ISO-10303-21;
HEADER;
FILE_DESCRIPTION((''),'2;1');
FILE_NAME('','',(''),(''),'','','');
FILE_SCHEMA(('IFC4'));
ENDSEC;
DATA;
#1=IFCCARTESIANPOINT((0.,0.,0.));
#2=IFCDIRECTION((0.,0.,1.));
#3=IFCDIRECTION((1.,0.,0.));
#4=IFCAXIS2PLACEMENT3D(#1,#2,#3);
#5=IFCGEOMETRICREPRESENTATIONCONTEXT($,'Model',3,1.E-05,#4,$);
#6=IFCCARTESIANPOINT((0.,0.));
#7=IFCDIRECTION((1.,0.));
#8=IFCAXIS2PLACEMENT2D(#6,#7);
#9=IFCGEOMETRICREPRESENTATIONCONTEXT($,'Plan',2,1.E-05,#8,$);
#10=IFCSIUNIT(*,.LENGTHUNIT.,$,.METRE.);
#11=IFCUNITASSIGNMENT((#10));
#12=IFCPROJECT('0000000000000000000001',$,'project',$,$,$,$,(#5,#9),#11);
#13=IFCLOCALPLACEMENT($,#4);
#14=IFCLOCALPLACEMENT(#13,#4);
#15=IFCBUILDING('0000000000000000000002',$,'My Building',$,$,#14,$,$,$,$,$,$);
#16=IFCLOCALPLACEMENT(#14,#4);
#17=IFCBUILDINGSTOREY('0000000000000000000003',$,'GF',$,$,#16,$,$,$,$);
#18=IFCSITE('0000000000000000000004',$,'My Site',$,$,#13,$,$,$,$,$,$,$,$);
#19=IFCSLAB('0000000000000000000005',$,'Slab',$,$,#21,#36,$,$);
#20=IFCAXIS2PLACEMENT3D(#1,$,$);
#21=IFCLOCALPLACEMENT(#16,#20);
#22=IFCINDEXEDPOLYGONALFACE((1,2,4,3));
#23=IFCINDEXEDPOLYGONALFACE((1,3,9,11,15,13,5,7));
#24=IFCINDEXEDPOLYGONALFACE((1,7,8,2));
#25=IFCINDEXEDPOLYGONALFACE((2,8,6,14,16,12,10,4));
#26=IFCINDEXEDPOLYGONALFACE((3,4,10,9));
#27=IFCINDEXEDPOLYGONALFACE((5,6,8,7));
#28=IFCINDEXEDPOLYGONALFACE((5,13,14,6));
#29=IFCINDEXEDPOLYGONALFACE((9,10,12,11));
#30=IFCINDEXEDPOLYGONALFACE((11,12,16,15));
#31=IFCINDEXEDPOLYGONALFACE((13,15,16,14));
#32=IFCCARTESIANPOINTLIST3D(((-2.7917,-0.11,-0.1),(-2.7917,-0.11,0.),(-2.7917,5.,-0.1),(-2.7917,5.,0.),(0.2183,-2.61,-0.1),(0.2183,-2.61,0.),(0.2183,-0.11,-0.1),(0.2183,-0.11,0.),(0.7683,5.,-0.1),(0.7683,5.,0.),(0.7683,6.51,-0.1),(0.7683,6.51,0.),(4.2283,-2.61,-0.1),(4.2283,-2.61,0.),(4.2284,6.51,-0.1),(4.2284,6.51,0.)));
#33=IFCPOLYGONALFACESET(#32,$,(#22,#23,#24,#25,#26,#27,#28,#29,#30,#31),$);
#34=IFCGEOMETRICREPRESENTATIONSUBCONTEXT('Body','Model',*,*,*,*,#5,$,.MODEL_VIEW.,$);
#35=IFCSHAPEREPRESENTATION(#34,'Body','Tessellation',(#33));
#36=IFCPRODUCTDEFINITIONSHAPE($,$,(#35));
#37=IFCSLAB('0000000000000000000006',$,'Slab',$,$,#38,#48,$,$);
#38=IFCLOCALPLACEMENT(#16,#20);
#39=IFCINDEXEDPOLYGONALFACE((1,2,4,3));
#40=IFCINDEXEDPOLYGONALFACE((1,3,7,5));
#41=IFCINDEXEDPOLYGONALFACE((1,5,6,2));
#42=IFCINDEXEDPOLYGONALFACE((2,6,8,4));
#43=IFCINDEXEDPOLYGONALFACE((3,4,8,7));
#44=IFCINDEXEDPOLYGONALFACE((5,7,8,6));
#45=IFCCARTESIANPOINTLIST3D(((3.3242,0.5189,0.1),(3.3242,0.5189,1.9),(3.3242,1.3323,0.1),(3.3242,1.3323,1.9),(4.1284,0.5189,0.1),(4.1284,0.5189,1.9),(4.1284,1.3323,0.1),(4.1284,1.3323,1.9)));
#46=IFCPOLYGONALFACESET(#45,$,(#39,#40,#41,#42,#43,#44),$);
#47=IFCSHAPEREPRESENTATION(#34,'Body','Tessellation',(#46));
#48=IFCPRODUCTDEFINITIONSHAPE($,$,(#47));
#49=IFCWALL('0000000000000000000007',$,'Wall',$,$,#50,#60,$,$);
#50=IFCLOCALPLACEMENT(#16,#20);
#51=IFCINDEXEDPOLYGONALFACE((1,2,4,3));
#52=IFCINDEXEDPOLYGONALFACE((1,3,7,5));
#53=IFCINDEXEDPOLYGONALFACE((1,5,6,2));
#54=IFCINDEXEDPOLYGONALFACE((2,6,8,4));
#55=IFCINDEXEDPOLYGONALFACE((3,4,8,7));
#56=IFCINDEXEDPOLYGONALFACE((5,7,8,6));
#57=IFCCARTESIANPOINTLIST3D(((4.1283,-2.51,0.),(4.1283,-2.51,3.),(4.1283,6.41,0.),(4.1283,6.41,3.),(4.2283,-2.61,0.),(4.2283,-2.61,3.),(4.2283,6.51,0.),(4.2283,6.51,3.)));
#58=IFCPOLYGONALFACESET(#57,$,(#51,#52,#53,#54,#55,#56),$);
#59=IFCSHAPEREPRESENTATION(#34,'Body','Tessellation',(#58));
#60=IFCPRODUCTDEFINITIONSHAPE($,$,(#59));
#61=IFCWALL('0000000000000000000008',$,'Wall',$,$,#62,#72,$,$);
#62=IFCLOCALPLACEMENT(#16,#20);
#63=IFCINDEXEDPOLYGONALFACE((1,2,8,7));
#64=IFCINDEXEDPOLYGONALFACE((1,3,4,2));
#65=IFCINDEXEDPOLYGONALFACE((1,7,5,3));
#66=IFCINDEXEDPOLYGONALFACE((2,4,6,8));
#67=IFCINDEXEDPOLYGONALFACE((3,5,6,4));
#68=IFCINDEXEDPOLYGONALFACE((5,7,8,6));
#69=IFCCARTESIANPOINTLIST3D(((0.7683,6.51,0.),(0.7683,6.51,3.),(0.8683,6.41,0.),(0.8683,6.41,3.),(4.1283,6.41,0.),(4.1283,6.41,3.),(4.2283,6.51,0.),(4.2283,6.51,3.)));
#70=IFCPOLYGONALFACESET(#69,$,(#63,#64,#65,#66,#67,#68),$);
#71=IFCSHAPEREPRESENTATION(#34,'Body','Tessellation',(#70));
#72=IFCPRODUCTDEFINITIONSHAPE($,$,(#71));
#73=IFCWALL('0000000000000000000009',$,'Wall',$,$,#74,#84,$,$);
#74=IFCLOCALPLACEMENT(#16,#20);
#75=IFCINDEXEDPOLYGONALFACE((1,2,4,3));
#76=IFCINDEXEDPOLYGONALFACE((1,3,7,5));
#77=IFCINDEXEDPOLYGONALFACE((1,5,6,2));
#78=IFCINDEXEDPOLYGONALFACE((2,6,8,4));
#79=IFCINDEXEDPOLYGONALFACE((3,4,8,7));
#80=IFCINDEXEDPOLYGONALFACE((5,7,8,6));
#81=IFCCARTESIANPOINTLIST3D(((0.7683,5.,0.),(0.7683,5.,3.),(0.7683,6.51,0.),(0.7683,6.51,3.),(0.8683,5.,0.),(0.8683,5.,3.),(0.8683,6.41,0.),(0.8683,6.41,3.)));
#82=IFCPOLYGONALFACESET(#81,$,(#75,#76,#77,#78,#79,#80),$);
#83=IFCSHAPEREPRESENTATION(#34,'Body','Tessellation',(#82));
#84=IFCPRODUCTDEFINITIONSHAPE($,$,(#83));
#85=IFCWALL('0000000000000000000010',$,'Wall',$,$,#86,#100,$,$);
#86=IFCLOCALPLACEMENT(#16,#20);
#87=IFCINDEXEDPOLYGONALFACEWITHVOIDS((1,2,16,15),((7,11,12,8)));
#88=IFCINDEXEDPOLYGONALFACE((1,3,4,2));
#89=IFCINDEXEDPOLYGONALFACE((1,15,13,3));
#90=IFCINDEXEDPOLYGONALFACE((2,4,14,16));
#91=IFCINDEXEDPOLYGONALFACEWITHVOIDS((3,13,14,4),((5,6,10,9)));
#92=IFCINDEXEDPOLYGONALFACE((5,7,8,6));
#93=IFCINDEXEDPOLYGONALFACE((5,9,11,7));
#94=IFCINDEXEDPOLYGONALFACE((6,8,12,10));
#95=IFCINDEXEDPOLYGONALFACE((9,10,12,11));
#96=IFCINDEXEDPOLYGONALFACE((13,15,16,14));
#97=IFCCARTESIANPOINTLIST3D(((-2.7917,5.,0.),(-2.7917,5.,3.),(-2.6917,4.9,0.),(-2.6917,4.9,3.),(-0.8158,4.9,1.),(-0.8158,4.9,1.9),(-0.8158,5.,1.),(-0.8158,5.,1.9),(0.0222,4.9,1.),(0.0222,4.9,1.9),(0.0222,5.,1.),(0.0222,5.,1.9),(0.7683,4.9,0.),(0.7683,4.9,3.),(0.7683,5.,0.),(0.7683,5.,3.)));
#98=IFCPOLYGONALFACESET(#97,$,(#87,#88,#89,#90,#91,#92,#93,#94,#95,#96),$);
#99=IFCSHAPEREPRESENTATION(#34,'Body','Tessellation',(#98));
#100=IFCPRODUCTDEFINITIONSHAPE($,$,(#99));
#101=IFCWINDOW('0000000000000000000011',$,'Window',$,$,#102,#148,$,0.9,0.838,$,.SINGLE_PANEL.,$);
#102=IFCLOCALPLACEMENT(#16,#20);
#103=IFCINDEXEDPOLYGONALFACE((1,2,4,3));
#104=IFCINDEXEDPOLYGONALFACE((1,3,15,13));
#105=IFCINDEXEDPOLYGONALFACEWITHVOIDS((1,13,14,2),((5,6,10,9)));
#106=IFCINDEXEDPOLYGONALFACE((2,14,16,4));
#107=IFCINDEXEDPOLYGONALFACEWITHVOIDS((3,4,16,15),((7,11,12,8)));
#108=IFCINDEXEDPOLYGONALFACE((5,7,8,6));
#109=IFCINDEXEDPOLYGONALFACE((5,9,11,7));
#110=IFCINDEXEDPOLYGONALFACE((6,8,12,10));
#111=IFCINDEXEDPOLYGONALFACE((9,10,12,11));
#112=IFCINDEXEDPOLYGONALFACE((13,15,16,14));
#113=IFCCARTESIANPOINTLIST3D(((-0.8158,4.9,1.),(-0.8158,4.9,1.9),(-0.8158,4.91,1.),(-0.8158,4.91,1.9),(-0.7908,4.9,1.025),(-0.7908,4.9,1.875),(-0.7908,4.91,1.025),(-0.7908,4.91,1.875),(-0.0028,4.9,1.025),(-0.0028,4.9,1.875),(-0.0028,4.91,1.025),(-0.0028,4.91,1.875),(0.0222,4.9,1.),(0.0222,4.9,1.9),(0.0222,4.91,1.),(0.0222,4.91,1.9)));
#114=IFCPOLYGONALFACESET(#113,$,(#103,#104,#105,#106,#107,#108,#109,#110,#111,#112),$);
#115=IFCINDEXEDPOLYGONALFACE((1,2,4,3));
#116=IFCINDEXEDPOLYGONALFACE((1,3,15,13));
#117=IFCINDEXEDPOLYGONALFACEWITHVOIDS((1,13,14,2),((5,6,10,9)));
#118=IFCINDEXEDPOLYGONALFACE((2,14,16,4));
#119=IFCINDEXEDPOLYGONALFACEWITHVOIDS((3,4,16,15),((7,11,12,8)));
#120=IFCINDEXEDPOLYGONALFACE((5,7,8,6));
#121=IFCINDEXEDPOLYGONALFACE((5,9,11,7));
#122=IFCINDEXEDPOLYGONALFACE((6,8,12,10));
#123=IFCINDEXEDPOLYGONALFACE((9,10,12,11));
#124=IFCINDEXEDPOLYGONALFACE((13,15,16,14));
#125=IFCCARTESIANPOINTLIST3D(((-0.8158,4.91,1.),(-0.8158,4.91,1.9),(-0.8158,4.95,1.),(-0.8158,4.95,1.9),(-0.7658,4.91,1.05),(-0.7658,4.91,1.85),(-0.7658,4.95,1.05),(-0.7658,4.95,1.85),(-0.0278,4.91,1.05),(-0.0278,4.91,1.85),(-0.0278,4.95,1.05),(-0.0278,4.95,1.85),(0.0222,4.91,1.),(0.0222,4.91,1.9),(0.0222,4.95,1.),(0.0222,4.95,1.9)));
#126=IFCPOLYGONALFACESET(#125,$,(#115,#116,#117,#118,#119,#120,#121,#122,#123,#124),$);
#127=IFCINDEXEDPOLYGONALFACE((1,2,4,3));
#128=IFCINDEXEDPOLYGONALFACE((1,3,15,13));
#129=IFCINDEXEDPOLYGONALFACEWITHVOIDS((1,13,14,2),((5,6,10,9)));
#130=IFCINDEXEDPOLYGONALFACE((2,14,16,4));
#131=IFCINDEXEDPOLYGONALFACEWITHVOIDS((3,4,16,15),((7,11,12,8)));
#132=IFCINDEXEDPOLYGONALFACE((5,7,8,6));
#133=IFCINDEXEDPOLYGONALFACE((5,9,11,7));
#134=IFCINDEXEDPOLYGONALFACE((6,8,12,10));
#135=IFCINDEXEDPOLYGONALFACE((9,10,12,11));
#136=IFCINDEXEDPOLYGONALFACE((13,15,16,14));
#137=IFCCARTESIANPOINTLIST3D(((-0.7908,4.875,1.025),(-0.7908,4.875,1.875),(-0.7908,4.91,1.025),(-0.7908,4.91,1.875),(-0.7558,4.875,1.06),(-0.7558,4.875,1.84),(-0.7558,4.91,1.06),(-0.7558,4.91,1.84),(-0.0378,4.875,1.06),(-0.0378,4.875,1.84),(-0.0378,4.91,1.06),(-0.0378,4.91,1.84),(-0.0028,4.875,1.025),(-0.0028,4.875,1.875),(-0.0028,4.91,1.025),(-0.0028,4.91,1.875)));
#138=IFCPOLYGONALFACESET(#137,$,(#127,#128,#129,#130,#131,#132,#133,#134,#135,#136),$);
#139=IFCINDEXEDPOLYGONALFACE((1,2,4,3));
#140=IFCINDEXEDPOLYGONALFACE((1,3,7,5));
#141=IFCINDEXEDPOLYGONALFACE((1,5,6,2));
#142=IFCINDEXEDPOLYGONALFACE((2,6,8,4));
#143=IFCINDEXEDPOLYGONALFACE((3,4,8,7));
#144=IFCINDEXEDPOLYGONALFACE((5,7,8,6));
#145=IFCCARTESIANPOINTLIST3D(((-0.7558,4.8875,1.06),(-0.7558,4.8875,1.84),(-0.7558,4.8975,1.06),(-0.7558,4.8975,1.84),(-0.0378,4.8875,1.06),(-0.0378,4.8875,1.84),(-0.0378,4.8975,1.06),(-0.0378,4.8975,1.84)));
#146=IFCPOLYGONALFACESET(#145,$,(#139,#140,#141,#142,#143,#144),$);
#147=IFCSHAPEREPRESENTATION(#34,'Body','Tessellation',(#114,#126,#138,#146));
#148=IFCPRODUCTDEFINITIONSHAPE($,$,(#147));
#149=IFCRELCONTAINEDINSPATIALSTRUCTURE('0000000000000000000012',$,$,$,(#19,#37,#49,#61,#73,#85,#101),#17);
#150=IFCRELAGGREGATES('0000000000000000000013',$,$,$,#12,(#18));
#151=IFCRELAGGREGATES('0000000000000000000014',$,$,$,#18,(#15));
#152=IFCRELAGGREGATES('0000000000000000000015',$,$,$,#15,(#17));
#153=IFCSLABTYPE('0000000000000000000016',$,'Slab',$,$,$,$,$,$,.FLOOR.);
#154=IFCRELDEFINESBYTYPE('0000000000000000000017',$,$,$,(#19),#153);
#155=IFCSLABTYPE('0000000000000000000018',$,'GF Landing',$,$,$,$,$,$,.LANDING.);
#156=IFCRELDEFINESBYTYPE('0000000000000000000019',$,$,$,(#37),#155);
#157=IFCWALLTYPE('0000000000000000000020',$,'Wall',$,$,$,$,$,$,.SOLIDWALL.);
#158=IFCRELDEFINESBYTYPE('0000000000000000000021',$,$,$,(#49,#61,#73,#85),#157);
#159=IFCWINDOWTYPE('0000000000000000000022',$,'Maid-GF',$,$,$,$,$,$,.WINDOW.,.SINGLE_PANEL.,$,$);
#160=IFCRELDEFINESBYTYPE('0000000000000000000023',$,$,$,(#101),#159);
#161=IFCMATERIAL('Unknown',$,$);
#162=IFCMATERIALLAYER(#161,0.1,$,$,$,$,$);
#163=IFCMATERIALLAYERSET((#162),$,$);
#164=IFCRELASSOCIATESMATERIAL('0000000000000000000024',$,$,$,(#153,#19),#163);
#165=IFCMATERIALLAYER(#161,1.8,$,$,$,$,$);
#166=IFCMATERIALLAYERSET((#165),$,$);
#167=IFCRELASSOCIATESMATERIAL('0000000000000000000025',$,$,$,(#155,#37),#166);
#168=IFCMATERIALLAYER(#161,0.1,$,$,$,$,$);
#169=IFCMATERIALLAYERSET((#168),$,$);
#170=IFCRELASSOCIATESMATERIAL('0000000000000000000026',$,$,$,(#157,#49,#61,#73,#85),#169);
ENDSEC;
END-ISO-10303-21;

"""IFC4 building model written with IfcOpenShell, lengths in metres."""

from ifc_helpers import new_model, entity, si_unit, frame, origin_with_axes, origin_2d_with_axis, place, context, subcontext, project, spatial, line, indexed_curve, outline, extrude, shape, source, transform, mapped, material, layer, layer_set, layer_usage, type_object, type_shapes, element, fill, save


model = new_model("IFC4")

# Units and contexts
model_context = context("Model", 3, precision=1e-05, world=origin_with_axes())
plan_context = context("Plan", 2, precision=1e-05, world=origin_2d_with_axis())
body_context_1 = subcontext(model_context, "Body", "Model", "MODEL_VIEW")
body_context_2 = subcontext(plan_context, "Body", "Plan", "PLAN_VIEW")
ifc_project = project(units=[si_unit("LENGTHUNIT", "METRE")], contexts=[model_context, plan_context])

# Site, building, storey
site_placement = place(None, origin_with_axes())
site = spatial("IfcSite", under=ifc_project, at=site_placement, Name="My Site")
building_placement = place(site_placement, origin_with_axes())
building = spatial("IfcBuilding", under=site, at=building_placement, Name="My Building")
storey_placement = place(building_placement, origin_with_axes())
storey = spatial("IfcBuildingStorey", under=building, at=storey_placement, Name="GF")

# Slabs
ifc_material = material(Name="Unknown")
ifc_layer_1 = layer(ifc_material, 0.1)
ifc_layer_set_1 = layer_set([ifc_layer_1])
ifc_layer_usage_1 = layer_usage(ifc_layer_set_1, "AXIS3", "POSITIVE", -0.1)
slab_type_1 = type_object("IfcSlabType", Name="Slab", PredefinedType="FLOOR", material=ifc_layer_set_1)
slab_1_placement = place(storey_placement, frame((0.2183, -2.61, 0.0), z_axis=(0.0, 0.0, 1.0), x_axis=(1.0, 0.0, 0.0)))
element("IfcSlab", 1, at=slab_1_placement, inside=storey, type_object=slab_type_1, material=ifc_layer_usage_1, Name="Slab", context=body_context_1, shape_type="SweptSolid", body=[
    extrude(outline(indexed_curve([(4.01, 0.0), (4.01, 9.12), (0.55, 9.12), (0.55, 7.61), (-3.01, 7.61), (-3.01, 2.5), (0.0, 2.5), (0.0, 0.0), (4.01, 0.0)])), frame((0.0, 0.0, -0.1), z_axis=(0.0, 0.0, 1.0), x_axis=(1.0, 0.0, 0.0)), (0.0, 0.0, 1.0), 0.1),
])
ifc_layer_2 = layer(ifc_material, 1.8)
ifc_layer_set_2 = layer_set([ifc_layer_2])
ifc_layer_usage_2 = layer_usage(ifc_layer_set_2, "AXIS3", "POSITIVE", -0.1)
slab_type_2 = type_object("IfcSlabType", Name="GF Landing", PredefinedType="LANDING", material=ifc_layer_set_2)
slab_2_placement = place(storey_placement, frame((3.3242, 1.3323, 0.2), z_axis=(0.0, 0.0, 1.0), x_axis=(1.0, 0.0, 0.0)))
element("IfcSlab", 2, at=slab_2_placement, inside=storey, type_object=slab_type_2, material=ifc_layer_usage_2, Name="Slab", context=body_context_1, shape_type="SweptSolid", body=[
    extrude(outline(indexed_curve([(0.0, 0.0), (0.0, -0.8134), (0.8042, -0.8134), (0.8042, 0.0), (0.0, 0.0)])), frame((0.0, 0.0, -0.1), z_axis=(0.0, 0.0, 1.0), x_axis=(1.0, 0.0, 0.0)), (0.0, 0.0, 1.0), 1.8),
])

# Shared definitions
ifc_layer_3 = layer(ifc_material, 0.1)
ifc_layer_set_3 = layer_set([ifc_layer_3])
wall_type = type_object("IfcWallType", Name="Wall", PredefinedType="SOLIDWALL", material=ifc_layer_set_3)

# Walls
ifc_layer_usage_3 = layer_usage(ifc_layer_set_3, "AXIS2", "POSITIVE", 0.0)
wall_1_placement = place(storey_placement, frame((4.2283, -2.61, 0.0), z_axis=(0.0, 0.0, 1.0), x_axis=(0.0, 1.0, 0.0)))
element("IfcWall", 3, at=wall_1_placement, inside=storey, type_object=wall_type, material=ifc_layer_usage_3, Name="Wall", context=body_context_1, shape_type="SweptSolid", body=[
    extrude(outline(indexed_curve([(0.0, 0.0), (0.1, 0.1), (9.02, 0.1), (9.12, 0.0)], segments=[line(1, 2, 3, 4, 1)])), origin_with_axes(), (0.0, 0.0, 1.0), 3.0),
])
ifc_layer_usage_4 = layer_usage(ifc_layer_set_3, "AXIS2", "POSITIVE", 0.0)
wall_2_placement = place(storey_placement, frame((4.2283, 6.51, 0.0), z_axis=(0.0, 0.0, 1.0), x_axis=(-1.0, 0.0, 0.0)))
element("IfcWall", 4, at=wall_2_placement, inside=storey, type_object=wall_type, material=ifc_layer_usage_4, Name="Wall", context=body_context_1, shape_type="SweptSolid", body=[
    extrude(outline(indexed_curve([(0.0, 0.0), (0.1, 0.1), (3.36, 0.1), (3.46, 0.0)], segments=[line(1, 2, 3, 4, 1)])), origin_with_axes(), (0.0, 0.0, 1.0), 3.0),
])
ifc_layer_usage_5 = layer_usage(ifc_layer_set_3, "AXIS2", "POSITIVE", 0.0)
wall_3_placement = place(storey_placement, frame((0.7683, 6.51, 0.0), z_axis=(0.0, 0.0, 1.0), x_axis=(0.0, -1.0, 0.0)))
element("IfcWall", 5, at=wall_3_placement, inside=storey, type_object=wall_type, material=ifc_layer_usage_5, Name="Wall", context=body_context_1, shape_type="SweptSolid", body=[
    extrude(outline(indexed_curve([(0.0, 0.0), (0.1, 0.1), (1.51, 0.1), (1.51, 0.0)], segments=[line(1, 2, 3, 4, 1)])), origin_with_axes(), (0.0, 0.0, 1.0), 3.0),
])

# Wall, opening, window
ifc_layer_usage_6 = layer_usage(ifc_layer_set_3, "AXIS2", "POSITIVE", 0.0)
wall_4_placement = place(storey_placement, frame((0.7683, 5.0, 0.0), z_axis=(0.0, 0.0, 1.0), x_axis=(-1.0, 0.0, 0.0)))
wall_4 = element("IfcWall", 6, at=wall_4_placement, inside=storey, type_object=wall_type, material=ifc_layer_usage_6, Name="Wall", context=body_context_1, shape_type="SweptSolid", body=[
    extrude(outline(indexed_curve([(0.0, 0.0), (0.0, 0.1), (3.46, 0.1), (3.56, 0.0)], segments=[line(1, 2, 3, 4, 1)])), origin_with_axes(), (0.0, 0.0, 1.0), 3.0),
])
shared_shape_1 = source(origin_with_axes(), body_context_1, "Body", "SweptSolid", [
    extrude(outline(indexed_curve([(0.0, 0.0), (0.838, 0.0), (0.838, 0.9), (0.0, 0.9)], segments=[line(1, 2, 3, 4, 1)])), frame((0.0, -0.6, 0.0), z_axis=(0.0, -1.0, 0.0), x_axis=(1.0, 0.0, 0.0)), (0.0, 0.0, -1.0), 1.2),
])
opening_1_placement = place(wall_4_placement, frame((0.7462, 0.0, 1.0), z_axis=(0.0, 0.0, 1.0), x_axis=(1.0, 0.0, 0.0)))
opening_1 = element("IfcOpeningElement", 7, at=opening_1_placement, cuts=wall_4, PredefinedType="OPENING", context=body_context_1, shape_type="MappedRepresentation", body=[
    mapped(shared_shape_1, transform((0.0, 0.0, 0.0), x_axis=(1.0, 0.0, 0.0), y_axis=(0.0, 1.0, 0.0), z_axis=(0.0, 0.0, 1.0), scale=1.0)),
])
window_type_1 = type_object("IfcWindowType", Name="Maid-GF", PartitioningType="SINGLE_PANEL", PredefinedType="WINDOW")
shared_shape_2 = source(origin_with_axes(), body_context_1, "Body", "SweptSolid", [
    extrude(outline(indexed_curve([(0.0, 0.0), (0.838, 0.0), (0.838, 0.9), (0.0, 0.9)], segments=[line(1, 2, 3, 4, 1)]), holes=[indexed_curve([(0.025, 0.025), (0.813, 0.025), (0.813, 0.875), (0.025, 0.875)], segments=[line(1, 2, 3, 4, 1)])]), frame((0.0, 0.09, 0.0), z_axis=(0.0, -1.0, 0.0), x_axis=(1.0, 0.0, 0.0)), (0.0, 0.0, -1.0), 0.01),
    extrude(outline(indexed_curve([(0.0, 0.0), (0.838, 0.0), (0.838, 0.9), (0.0, 0.9)], segments=[line(1, 2, 3, 4, 1)]), holes=[indexed_curve([(0.05, 0.05), (0.788, 0.05), (0.788, 0.85), (0.05, 0.85)], segments=[line(1, 2, 3, 4, 1)])]), frame((0.0, 0.05, 0.0), z_axis=(0.0, -1.0, 0.0), x_axis=(1.0, 0.0, 0.0)), (0.0, 0.0, -1.0), 0.04),
    extrude(outline(indexed_curve([(0.0, 0.0), (0.788, 0.0), (0.788, 0.85), (0.0, 0.85)], segments=[line(1, 2, 3, 4, 1)]), holes=[indexed_curve([(0.035, 0.035), (0.753, 0.035), (0.753, 0.815), (0.035, 0.815)], segments=[line(1, 2, 3, 4, 1)])]), frame((0.025, 0.09, 0.025), z_axis=(0.0, -1.0, 0.0), x_axis=(1.0, 0.0, 0.0)), (0.0, 0.0, -1.0), 0.035),
    extrude(outline(indexed_curve([(0.035, 0.035), (0.753, 0.035), (0.753, 0.815), (0.035, 0.815)], segments=[line(1, 2, 3, 4, 1)])), frame((0.025, 0.1025, 0.025), z_axis=(0.0, -1.0, 0.0), x_axis=(1.0, 0.0, 0.0)), (0.0, 0.0, -1.0), 0.01),
])
shared_shape_3 = source(origin_with_axes(), body_context_2, "Body", "Curve2D", [
    entity("IfcIndexedPolyCurve", entity("IfcCartesianPointList2D", [[0.05, 0.05], [0.788, 0.05]])),
    entity("IfcIndexedPolyCurve", entity("IfcCartesianPointList2D", [[0.0, 0.1], [0.025, 0.1], [0.025, 0.09], [0.05, 0.09], [0.05, 0.05], [0.0, 0.05]]), [entity("IfcLineIndex", [1, 2, 3, 4, 5, 6, 1])]),
    entity("IfcIndexedPolyCurve", entity("IfcCartesianPointList2D", [[0.838, 0.1], [0.813, 0.1], [0.813, 0.09], [0.788, 0.09], [0.788, 0.05], [0.838, 0.05]]), [entity("IfcLineIndex", [1, 2, 3, 4, 5, 6, 1])]),
    entity("IfcIndexedPolyCurve", entity("IfcCartesianPointList2D", [[0.025, 0.09], [0.06, 0.09], [0.06, 0.125], [0.025, 0.125]]), [entity("IfcLineIndex", [1, 2, 3, 4, 1])]),
    entity("IfcIndexedPolyCurve", entity("IfcCartesianPointList2D", [[0.813, 0.09], [0.778, 0.09], [0.778, 0.125], [0.813, 0.125]]), [entity("IfcLineIndex", [1, 2, 3, 4, 1])]),
    entity("IfcIndexedPolyCurve", entity("IfcCartesianPointList2D", [[0.06, 0.09], [0.778, 0.09]])),
    entity("IfcIndexedPolyCurve", entity("IfcCartesianPointList2D", [[0.06, 0.125], [0.778, 0.125]])),
    entity("IfcIndexedPolyCurve", entity("IfcCartesianPointList2D", [[0.06, 0.1075], [0.778, 0.1075]])),
])
type_shapes(window_type_1, [shared_shape_2, shared_shape_3])
window_1_placement = place(opening_1_placement, origin_with_axes())
window_1 = element("IfcWindow", 8, at=window_1_placement, inside=storey, type_object=window_type_1, Name="Window", OverallHeight=0.9, OverallWidth=0.838, PartitioningType="SINGLE_PANEL", shapes=[
    shape(body_context_1, "Body", "MappedRepresentation", [mapped(shared_shape_2, transform((0.0, 0.0, 0.0), x_axis=(1.0, 0.0, 0.0), y_axis=(0.0, 1.0, 0.0), z_axis=(0.0, 0.0, 1.0), scale=1.0))]),
    shape(body_context_2, "Body", "MappedRepresentation", [mapped(shared_shape_3, transform((0.0, 0.0, 0.0), x_axis=(1.0, 0.0, 0.0), y_axis=(0.0, 1.0, 0.0), z_axis=(0.0, 0.0, 1.0), scale=1.0))]),
])
fill(opening_1, window_1)

save(model, "model.ifc")
